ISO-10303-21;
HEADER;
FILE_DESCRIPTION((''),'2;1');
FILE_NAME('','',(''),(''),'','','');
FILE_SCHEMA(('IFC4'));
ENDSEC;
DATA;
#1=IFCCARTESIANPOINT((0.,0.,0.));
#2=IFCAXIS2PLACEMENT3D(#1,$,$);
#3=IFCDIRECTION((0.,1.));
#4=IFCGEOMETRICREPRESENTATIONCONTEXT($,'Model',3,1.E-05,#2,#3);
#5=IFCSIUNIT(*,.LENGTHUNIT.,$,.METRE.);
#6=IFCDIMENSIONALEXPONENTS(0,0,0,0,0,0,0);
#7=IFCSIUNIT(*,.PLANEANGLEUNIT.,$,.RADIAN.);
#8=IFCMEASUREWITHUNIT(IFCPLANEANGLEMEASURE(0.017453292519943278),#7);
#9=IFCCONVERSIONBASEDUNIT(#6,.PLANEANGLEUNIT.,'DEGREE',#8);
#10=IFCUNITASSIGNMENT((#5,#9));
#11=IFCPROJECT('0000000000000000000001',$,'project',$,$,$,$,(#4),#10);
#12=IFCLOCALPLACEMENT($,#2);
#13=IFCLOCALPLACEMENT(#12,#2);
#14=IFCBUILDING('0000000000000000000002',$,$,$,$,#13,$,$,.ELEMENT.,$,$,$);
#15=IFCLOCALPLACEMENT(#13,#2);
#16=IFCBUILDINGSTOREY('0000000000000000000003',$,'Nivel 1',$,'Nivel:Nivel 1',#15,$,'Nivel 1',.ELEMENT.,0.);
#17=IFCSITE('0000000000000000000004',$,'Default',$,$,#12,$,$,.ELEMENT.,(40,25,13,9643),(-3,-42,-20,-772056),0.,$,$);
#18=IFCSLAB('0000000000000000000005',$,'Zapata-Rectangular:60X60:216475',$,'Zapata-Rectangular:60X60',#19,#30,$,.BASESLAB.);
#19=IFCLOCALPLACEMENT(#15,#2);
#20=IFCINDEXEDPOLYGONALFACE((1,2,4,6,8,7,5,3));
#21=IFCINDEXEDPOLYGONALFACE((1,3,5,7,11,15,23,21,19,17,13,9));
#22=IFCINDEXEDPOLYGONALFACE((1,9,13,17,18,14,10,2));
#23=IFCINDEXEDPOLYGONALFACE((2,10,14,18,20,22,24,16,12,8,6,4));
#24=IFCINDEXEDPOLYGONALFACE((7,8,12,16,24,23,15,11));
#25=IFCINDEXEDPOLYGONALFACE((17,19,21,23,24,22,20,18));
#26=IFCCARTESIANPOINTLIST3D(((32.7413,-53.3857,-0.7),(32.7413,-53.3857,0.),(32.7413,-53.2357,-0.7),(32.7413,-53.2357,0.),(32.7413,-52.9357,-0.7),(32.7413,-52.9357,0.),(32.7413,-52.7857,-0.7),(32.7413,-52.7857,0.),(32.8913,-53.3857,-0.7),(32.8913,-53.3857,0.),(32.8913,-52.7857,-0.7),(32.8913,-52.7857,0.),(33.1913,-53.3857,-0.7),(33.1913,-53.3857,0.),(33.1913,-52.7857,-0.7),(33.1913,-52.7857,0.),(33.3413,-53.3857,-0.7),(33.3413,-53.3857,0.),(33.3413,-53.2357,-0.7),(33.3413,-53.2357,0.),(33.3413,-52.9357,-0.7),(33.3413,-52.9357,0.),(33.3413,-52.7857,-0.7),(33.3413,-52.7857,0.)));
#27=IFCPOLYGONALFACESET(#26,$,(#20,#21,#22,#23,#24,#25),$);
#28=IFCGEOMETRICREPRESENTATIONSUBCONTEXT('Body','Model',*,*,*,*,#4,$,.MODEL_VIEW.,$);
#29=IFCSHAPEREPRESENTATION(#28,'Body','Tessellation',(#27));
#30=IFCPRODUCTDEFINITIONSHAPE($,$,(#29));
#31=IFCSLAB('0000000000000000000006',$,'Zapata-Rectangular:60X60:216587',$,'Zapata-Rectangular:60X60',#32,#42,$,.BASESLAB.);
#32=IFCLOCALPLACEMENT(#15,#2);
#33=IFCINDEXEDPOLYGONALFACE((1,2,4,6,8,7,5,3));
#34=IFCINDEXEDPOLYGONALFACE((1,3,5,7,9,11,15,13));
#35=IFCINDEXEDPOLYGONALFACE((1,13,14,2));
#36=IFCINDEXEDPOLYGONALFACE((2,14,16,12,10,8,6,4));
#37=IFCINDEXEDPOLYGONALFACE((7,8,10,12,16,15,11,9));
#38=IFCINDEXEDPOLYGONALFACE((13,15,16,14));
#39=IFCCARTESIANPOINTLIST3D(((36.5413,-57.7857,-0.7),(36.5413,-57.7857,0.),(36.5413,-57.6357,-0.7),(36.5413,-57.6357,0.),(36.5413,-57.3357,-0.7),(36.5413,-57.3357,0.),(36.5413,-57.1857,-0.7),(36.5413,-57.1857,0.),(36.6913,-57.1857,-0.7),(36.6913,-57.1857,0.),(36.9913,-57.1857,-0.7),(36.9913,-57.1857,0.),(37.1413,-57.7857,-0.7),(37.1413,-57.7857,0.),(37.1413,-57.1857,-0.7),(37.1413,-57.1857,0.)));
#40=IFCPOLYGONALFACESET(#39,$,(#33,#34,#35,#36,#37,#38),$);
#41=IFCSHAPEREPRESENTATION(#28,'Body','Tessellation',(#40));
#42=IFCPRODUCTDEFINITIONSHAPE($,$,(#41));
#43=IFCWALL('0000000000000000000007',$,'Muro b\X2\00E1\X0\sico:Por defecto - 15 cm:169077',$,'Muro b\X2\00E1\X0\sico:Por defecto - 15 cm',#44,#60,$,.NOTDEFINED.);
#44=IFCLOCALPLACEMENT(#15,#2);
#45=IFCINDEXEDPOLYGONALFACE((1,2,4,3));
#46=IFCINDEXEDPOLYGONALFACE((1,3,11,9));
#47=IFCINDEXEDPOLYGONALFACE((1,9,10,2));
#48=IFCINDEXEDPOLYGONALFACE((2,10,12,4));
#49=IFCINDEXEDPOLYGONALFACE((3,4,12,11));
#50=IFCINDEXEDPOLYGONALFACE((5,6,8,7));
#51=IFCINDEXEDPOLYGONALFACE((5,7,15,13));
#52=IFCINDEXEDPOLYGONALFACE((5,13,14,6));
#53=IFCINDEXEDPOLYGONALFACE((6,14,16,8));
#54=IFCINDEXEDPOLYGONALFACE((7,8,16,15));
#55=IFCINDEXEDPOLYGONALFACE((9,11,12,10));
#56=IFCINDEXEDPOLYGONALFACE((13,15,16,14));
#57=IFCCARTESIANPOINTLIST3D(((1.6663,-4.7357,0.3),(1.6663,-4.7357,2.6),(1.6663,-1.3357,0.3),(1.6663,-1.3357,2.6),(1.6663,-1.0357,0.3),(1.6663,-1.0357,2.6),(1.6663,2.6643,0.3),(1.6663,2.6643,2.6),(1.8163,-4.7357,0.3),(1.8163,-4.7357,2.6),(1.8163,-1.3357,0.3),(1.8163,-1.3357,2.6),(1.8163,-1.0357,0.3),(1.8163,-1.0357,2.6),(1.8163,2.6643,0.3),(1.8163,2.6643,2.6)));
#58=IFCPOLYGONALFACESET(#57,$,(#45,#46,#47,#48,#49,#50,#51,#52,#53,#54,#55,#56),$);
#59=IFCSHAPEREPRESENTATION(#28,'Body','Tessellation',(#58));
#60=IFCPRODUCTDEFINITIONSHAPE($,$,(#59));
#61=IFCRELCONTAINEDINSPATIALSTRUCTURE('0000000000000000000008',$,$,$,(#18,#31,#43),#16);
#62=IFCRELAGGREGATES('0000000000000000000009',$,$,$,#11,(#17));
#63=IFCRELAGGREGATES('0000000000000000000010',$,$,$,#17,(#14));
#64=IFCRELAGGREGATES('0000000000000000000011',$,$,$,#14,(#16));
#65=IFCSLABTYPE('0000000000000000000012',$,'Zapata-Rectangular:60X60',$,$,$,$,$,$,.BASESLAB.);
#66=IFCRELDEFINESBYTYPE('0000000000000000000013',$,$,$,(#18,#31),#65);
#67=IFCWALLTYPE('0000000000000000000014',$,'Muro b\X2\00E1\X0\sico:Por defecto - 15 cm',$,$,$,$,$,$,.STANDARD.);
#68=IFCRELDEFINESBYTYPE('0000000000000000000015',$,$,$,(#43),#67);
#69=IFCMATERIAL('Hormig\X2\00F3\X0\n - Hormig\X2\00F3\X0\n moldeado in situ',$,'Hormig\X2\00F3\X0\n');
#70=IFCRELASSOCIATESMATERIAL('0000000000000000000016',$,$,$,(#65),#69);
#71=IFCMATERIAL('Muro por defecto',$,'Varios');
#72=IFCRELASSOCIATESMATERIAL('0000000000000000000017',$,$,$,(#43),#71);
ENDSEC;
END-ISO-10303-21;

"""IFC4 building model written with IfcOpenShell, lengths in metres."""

from ifc_helpers import new_model, entity, si_unit, converted_unit, direction, frame, origin, place, context, subcontext, project, spatial, indexed_curve, outline, extrude, material, type_object, element, save


model = new_model("IFC4")

# Units and contexts
model_context = context("Model", 3, precision=1e-05, world=origin(), true_north=direction((0.0, 1.0)))
body_context = subcontext(model_context, "Body", "Model", "MODEL_VIEW")
ifc_project = project(units=[si_unit("LENGTHUNIT", "METRE"), converted_unit("PLANEANGLEUNIT", "DEGREE", entity("IfcPlaneAngleMeasure", 0.017453292519943278), si_unit("PLANEANGLEUNIT", "RADIAN"), dimensions=[0, 0, 0, 0, 0, 0, 0])], contexts=[model_context])

# Site, building, storey
site_placement = place(None, origin())
site = spatial("IfcSite", under=ifc_project, at=site_placement, Name="Default", CompositionType="ELEMENT", RefLatitude=(40, 25, 13, 9643), RefLongitude=(-3, -42, -20, -772056), RefElevation=0.0)
building_placement = place(site_placement, origin())
building = spatial("IfcBuilding", under=site, at=building_placement, CompositionType="ELEMENT")
storey_placement = place(building_placement, origin())
storey = spatial("IfcBuildingStorey", under=building, at=storey_placement, Name="Nivel 1", ObjectType="Nivel:Nivel 1", LongName="Nivel 1", CompositionType="ELEMENT", Elevation=0.0)

# Slabs
ifc_material_1 = material(Name="Hormigón - Hormigón moldeado in situ", Category="Hormigón")
slab_type_1 = type_object("IfcSlabType", Name="Zapata-Rectangular:60X60", PredefinedType="BASESLAB", material=ifc_material_1)
slab_1_placement = place(storey_placement, origin())
element("IfcSlab", 1, at=slab_1_placement, inside=storey, type_object=slab_type_1, Name="Zapata-Rectangular:60X60:216475", ObjectType="Zapata-Rectangular:60X60", PredefinedType="BASESLAB", context=body_context, shape_type="SweptSolid", body=[
    extrude(outline(indexed_curve([(-0.3, -0.3), (-0.15, -0.3), (0.15, -0.3), (0.3, -0.3), (0.3, -0.15), (0.3, 0.15), (0.3, 0.3), (0.15, 0.3), (-0.15, 0.3), (-0.3, 0.3), (-0.3, 0.15), (-0.3, -0.15), (-0.3, -0.3)], self_intersect=False)), frame((33.0413, -53.0857, -0.7), z_axis=(0.0, 0.0, 1.0), x_axis=(-1.0, 0.0, 0.0)), (0.0, 0.0, 1.0), 0.7),
])
slab_2_placement = place(storey_placement, origin())
element("IfcSlab", 2, at=slab_2_placement, inside=storey, type_object=slab_type_1, Name="Zapata-Rectangular:60X60:216587", ObjectType="Zapata-Rectangular:60X60", PredefinedType="BASESLAB", context=body_context, shape_type="SweptSolid", body=[
    extrude(outline(indexed_curve([(-0.375, -0.225), (-0.225, -0.225), (0.075, -0.225), (0.225, -0.225), (0.225, -0.075), (0.225, 0.225), (0.225, 0.375), (-0.375, 0.375), (-0.375, -0.225)], self_intersect=False)), frame((36.7663, -57.4107, -0.7), z_axis=(0.0, 0.0, 1.0), x_axis=(-1.0, 0.0, 0.0)), (0.0, 0.0, 1.0), 0.7),
])

# Wall, opening
ifc_material_2 = material(Name="Muro por defecto", Category="Varios")
wall_type = type_object("IfcWallType", Name="Muro básico:Por defecto - 15 cm", PredefinedType="STANDARD")
wall_placement = place(storey_placement, frame((1.7413, 2.6643, 0.3), z_axis=(0.0, 0.0, 1.0), x_axis=(0.0, -1.0, 0.0)))
wall = element("IfcWall", 3, at=wall_placement, inside=storey, type_object=wall_type, material=ifc_material_2, Name="Muro básico:Por defecto - 15 cm:169077", ObjectType="Muro básico:Por defecto - 15 cm", PredefinedType="NOTDEFINED", context=body_context, shape_type="SweptSolid", body=[
    extrude(outline(indexed_curve([(7.4, 0.075), (0.0, 0.075), (0.0, -0.075), (7.4, -0.075), (7.4, 0.075)], self_intersect=False)), origin(), (0.0, 0.0, 1.0), 2.3),
])
opening_placement = place(storey_placement, frame((1.7413, 2.6643, 0.3), z_axis=(0.0, 0.0, 1.0), x_axis=(0.0, -1.0, 0.0)))
element("IfcOpeningElement", 4, at=opening_placement, cuts=wall, PredefinedType="OPENING", context=body_context, shape_type="SweptSolid", body=[
    extrude(outline(indexed_curve([(-1.15, -0.075), (1.15, -0.075), (1.15, 0.075), (-1.15, 0.075), (-1.15, -0.075)], self_intersect=False)), frame((4.0, 0.0, 1.15), z_axis=(-1.0, 0.0, 0.0), x_axis=(0.0, 0.0, 1.0)), (0.0, 0.0, 1.0), 0.3),
])

save(model, "model.ifc")
